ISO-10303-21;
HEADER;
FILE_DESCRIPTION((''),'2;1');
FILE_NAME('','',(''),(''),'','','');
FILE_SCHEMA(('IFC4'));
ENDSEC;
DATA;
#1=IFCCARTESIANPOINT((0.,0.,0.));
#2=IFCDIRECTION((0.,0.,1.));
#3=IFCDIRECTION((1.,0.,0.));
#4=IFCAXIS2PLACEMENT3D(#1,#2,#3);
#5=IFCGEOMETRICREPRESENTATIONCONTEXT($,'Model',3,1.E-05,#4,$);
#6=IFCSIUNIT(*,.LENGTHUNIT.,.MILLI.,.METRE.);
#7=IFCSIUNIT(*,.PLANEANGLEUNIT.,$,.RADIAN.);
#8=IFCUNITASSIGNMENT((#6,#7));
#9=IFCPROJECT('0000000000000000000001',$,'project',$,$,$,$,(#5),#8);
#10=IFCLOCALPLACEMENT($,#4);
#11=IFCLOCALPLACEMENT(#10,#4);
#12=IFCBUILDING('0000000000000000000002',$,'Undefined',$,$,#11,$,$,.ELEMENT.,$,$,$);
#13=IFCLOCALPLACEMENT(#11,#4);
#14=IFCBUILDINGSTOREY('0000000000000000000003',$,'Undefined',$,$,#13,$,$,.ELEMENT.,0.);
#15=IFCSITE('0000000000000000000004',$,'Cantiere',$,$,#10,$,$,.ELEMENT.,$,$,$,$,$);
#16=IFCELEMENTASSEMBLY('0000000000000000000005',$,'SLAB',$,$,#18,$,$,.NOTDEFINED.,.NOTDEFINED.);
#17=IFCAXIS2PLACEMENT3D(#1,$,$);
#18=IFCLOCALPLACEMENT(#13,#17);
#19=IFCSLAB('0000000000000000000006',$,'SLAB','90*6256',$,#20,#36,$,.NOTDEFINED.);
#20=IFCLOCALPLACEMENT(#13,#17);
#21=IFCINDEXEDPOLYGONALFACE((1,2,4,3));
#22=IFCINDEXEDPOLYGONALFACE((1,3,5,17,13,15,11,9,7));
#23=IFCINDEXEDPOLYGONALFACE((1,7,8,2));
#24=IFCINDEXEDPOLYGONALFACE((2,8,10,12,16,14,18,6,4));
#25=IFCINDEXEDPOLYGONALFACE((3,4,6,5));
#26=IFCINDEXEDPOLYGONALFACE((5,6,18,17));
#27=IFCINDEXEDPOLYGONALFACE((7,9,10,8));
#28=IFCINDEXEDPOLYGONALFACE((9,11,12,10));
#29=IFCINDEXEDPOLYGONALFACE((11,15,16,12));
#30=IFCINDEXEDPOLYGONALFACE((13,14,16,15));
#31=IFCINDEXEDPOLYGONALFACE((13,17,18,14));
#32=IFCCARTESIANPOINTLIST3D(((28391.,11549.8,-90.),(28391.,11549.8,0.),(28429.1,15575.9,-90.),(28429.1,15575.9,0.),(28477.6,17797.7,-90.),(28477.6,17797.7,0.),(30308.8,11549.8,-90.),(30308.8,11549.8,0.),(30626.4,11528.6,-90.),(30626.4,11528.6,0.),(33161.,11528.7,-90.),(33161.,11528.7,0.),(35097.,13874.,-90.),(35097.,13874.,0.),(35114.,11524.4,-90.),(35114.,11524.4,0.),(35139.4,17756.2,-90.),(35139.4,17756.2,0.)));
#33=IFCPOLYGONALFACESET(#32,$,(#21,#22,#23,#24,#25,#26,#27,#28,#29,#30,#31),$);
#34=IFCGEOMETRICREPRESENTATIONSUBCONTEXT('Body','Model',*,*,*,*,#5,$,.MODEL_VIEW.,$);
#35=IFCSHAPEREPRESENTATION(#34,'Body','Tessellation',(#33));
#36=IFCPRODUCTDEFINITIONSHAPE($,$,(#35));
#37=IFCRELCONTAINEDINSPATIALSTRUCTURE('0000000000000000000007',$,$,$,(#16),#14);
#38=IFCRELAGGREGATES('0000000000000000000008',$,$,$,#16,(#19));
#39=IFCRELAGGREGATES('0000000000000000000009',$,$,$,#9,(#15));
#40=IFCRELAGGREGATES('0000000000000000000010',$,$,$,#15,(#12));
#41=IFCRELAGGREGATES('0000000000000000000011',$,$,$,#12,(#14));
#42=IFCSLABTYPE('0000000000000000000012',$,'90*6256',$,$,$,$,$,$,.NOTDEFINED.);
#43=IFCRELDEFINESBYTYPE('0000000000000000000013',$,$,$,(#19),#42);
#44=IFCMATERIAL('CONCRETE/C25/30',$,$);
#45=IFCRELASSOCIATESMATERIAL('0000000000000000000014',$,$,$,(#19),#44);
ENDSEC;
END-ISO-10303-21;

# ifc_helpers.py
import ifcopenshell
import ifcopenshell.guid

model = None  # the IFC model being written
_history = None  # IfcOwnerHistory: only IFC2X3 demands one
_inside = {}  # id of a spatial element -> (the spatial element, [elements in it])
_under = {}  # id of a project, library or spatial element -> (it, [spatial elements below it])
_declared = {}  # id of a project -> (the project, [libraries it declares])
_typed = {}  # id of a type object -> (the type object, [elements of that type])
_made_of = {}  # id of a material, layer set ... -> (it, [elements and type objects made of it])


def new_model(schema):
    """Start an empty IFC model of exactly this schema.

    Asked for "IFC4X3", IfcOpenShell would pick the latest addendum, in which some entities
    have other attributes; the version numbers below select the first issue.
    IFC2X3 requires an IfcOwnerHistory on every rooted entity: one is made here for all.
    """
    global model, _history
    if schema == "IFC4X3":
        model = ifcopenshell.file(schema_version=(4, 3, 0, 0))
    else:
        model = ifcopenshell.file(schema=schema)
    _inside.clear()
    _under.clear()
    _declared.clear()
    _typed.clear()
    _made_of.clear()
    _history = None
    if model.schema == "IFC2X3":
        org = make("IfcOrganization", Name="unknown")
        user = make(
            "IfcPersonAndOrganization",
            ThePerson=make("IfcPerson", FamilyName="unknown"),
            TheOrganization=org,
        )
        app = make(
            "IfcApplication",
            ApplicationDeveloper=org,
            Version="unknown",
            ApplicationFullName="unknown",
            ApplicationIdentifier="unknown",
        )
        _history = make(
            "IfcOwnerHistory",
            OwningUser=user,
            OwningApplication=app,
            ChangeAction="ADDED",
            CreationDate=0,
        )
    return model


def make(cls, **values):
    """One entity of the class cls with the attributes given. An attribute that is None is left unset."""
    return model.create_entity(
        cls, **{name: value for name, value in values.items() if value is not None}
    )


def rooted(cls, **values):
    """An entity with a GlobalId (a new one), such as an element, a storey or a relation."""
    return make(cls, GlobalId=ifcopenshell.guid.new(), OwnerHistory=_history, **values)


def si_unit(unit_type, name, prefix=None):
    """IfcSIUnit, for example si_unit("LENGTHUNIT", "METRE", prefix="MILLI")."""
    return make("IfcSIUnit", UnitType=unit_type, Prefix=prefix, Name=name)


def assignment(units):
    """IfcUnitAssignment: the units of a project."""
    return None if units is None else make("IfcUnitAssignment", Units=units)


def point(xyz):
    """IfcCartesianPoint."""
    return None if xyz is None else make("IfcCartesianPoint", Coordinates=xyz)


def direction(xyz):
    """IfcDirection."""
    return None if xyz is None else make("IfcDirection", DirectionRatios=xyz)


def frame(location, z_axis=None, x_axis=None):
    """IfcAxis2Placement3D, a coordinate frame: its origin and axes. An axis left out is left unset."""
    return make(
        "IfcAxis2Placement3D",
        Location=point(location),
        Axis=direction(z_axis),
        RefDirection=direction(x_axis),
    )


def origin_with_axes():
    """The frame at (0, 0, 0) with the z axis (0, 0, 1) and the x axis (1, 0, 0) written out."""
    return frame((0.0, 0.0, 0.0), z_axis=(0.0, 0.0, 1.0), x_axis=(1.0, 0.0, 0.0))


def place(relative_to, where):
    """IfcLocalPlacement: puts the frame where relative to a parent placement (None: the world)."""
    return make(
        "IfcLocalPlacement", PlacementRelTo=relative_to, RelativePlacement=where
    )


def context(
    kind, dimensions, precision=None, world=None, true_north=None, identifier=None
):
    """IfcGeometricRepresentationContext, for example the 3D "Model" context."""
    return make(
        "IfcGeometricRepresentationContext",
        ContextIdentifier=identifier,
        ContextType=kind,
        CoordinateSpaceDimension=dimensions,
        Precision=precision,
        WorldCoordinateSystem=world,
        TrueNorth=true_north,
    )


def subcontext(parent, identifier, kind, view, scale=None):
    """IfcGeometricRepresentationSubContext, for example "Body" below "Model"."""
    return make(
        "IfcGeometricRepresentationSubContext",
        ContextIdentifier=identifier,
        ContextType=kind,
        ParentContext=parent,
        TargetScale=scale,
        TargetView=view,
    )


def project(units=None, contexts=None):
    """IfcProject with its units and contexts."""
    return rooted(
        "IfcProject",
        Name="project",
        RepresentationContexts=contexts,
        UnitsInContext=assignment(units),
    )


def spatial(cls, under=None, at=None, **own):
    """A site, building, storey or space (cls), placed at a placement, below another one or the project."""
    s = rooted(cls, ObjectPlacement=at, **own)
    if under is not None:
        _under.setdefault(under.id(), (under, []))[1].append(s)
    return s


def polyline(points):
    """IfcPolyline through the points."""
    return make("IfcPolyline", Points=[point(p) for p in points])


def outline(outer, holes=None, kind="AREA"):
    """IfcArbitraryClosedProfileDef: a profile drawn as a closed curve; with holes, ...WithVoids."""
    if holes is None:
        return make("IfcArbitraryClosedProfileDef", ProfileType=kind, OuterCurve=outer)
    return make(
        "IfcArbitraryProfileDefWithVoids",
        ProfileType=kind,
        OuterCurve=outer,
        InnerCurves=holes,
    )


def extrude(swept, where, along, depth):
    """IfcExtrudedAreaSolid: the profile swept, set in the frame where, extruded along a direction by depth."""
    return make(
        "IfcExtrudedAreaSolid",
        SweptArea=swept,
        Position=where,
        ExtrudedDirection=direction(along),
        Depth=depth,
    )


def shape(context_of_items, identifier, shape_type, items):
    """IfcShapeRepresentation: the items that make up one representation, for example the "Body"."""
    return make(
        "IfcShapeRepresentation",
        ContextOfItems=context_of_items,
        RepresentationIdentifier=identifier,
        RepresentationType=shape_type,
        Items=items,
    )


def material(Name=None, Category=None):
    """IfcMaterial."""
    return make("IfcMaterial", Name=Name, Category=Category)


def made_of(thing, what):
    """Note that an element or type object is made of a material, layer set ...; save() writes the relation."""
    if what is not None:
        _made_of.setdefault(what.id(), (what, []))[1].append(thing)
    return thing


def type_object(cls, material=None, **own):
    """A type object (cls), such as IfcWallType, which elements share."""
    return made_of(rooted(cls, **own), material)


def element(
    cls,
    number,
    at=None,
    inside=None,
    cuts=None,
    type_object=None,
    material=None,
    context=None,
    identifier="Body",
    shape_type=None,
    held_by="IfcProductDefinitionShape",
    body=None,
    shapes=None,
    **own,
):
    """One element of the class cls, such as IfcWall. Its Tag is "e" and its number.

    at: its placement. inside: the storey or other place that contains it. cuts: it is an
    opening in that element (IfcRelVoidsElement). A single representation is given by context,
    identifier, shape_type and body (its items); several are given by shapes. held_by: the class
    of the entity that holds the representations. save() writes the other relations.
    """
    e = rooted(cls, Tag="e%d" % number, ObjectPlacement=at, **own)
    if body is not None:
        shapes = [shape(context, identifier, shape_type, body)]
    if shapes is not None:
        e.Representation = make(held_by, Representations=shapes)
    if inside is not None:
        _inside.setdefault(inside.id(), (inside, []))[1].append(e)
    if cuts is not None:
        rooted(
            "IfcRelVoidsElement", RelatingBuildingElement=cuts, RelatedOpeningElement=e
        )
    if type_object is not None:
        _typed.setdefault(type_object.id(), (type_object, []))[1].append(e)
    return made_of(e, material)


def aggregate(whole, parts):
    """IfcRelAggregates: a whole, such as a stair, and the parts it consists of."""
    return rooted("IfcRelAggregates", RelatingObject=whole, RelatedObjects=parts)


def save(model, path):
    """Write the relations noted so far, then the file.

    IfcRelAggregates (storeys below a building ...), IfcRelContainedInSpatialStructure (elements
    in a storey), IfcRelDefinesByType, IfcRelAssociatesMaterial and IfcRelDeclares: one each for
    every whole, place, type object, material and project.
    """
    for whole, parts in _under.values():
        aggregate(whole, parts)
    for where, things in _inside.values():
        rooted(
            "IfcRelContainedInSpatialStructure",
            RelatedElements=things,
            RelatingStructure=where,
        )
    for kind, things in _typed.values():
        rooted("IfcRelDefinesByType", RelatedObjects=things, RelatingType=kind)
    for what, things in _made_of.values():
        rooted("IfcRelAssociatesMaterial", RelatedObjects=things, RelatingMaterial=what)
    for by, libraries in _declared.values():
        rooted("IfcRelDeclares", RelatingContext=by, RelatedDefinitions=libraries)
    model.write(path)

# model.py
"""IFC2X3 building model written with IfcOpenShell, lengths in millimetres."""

from ifc_helpers import new_model, si_unit, frame, origin_with_axes, place, context, subcontext, project, spatial, polyline, outline, extrude, material, type_object, element, aggregate, save


model = new_model("IFC2X3")

# Units and contexts
model_context = context("Model", 3, precision=1e-05, world=origin_with_axes())
body_context = subcontext(model_context, "Body", "Model", "MODEL_VIEW")
ifc_project = project(units=[si_unit("LENGTHUNIT", "METRE", prefix="MILLI"), si_unit("PLANEANGLEUNIT", "RADIAN")], contexts=[model_context])

# Site, building, storey
site_placement = place(None, origin_with_axes())
site = spatial("IfcSite", under=ifc_project, at=site_placement, Name="Cantiere", CompositionType="ELEMENT")
building_placement = place(site_placement, origin_with_axes())
building = spatial("IfcBuilding", under=site, at=building_placement, Name="Undefined", CompositionType="ELEMENT")
storey_placement = place(building_placement, origin_with_axes())
storey = spatial("IfcBuildingStorey", under=building, at=storey_placement, Name="Undefined", CompositionType="ELEMENT", Elevation=0.0)

# Element assembly, slab
assembly_1_placement = place(storey_placement, origin_with_axes())
assembly_1 = element("IfcElementAssembly", 1, at=assembly_1_placement, inside=storey, Name="SLAB", AssemblyPlace="NOTDEFINED", PredefinedType="NOTDEFINED")
ifc_material_1 = material(Name="CONCRETE/C25/30")
slab_type = type_object("IfcSlabType", Name="90*6256", PredefinedType="NOTDEFINED")
slab_placement = place(assembly_1_placement, frame((35139.4, 17756.2, -45.0), z_axis=(0.0, 0.0, 1.0), x_axis=(-0.999981, 0.006225, 0.0)))
slab = element("IfcSlab", 2, at=slab_placement, type_object=slab_type, material=ifc_material_1, Name="SLAB", Description="90*6256", PredefinedType="NOTDEFINED", context=body_context, shape_type="SweptSolid", body=[
    extrude(outline(polyline([(0.0, 0.0), (6661.9, 0.0), (6696.6, 2222.0), (6709.6, 6248.3), (4791.8, 6236.4), (4474.2, 6255.6), (1939.6, 6239.7), (-13.4, 6231.9), (18.2, 3882.4), (0.0, 0.0)])), frame((0.0, 0.0, -45.0), z_axis=(0.0, 0.0, 1.0), x_axis=(1.0, 0.0, 0.0)), (0.0, 0.0, 1.0), 90.0),
])
aggregate(assembly_1, [slab])

save(model, "model.ifc")
